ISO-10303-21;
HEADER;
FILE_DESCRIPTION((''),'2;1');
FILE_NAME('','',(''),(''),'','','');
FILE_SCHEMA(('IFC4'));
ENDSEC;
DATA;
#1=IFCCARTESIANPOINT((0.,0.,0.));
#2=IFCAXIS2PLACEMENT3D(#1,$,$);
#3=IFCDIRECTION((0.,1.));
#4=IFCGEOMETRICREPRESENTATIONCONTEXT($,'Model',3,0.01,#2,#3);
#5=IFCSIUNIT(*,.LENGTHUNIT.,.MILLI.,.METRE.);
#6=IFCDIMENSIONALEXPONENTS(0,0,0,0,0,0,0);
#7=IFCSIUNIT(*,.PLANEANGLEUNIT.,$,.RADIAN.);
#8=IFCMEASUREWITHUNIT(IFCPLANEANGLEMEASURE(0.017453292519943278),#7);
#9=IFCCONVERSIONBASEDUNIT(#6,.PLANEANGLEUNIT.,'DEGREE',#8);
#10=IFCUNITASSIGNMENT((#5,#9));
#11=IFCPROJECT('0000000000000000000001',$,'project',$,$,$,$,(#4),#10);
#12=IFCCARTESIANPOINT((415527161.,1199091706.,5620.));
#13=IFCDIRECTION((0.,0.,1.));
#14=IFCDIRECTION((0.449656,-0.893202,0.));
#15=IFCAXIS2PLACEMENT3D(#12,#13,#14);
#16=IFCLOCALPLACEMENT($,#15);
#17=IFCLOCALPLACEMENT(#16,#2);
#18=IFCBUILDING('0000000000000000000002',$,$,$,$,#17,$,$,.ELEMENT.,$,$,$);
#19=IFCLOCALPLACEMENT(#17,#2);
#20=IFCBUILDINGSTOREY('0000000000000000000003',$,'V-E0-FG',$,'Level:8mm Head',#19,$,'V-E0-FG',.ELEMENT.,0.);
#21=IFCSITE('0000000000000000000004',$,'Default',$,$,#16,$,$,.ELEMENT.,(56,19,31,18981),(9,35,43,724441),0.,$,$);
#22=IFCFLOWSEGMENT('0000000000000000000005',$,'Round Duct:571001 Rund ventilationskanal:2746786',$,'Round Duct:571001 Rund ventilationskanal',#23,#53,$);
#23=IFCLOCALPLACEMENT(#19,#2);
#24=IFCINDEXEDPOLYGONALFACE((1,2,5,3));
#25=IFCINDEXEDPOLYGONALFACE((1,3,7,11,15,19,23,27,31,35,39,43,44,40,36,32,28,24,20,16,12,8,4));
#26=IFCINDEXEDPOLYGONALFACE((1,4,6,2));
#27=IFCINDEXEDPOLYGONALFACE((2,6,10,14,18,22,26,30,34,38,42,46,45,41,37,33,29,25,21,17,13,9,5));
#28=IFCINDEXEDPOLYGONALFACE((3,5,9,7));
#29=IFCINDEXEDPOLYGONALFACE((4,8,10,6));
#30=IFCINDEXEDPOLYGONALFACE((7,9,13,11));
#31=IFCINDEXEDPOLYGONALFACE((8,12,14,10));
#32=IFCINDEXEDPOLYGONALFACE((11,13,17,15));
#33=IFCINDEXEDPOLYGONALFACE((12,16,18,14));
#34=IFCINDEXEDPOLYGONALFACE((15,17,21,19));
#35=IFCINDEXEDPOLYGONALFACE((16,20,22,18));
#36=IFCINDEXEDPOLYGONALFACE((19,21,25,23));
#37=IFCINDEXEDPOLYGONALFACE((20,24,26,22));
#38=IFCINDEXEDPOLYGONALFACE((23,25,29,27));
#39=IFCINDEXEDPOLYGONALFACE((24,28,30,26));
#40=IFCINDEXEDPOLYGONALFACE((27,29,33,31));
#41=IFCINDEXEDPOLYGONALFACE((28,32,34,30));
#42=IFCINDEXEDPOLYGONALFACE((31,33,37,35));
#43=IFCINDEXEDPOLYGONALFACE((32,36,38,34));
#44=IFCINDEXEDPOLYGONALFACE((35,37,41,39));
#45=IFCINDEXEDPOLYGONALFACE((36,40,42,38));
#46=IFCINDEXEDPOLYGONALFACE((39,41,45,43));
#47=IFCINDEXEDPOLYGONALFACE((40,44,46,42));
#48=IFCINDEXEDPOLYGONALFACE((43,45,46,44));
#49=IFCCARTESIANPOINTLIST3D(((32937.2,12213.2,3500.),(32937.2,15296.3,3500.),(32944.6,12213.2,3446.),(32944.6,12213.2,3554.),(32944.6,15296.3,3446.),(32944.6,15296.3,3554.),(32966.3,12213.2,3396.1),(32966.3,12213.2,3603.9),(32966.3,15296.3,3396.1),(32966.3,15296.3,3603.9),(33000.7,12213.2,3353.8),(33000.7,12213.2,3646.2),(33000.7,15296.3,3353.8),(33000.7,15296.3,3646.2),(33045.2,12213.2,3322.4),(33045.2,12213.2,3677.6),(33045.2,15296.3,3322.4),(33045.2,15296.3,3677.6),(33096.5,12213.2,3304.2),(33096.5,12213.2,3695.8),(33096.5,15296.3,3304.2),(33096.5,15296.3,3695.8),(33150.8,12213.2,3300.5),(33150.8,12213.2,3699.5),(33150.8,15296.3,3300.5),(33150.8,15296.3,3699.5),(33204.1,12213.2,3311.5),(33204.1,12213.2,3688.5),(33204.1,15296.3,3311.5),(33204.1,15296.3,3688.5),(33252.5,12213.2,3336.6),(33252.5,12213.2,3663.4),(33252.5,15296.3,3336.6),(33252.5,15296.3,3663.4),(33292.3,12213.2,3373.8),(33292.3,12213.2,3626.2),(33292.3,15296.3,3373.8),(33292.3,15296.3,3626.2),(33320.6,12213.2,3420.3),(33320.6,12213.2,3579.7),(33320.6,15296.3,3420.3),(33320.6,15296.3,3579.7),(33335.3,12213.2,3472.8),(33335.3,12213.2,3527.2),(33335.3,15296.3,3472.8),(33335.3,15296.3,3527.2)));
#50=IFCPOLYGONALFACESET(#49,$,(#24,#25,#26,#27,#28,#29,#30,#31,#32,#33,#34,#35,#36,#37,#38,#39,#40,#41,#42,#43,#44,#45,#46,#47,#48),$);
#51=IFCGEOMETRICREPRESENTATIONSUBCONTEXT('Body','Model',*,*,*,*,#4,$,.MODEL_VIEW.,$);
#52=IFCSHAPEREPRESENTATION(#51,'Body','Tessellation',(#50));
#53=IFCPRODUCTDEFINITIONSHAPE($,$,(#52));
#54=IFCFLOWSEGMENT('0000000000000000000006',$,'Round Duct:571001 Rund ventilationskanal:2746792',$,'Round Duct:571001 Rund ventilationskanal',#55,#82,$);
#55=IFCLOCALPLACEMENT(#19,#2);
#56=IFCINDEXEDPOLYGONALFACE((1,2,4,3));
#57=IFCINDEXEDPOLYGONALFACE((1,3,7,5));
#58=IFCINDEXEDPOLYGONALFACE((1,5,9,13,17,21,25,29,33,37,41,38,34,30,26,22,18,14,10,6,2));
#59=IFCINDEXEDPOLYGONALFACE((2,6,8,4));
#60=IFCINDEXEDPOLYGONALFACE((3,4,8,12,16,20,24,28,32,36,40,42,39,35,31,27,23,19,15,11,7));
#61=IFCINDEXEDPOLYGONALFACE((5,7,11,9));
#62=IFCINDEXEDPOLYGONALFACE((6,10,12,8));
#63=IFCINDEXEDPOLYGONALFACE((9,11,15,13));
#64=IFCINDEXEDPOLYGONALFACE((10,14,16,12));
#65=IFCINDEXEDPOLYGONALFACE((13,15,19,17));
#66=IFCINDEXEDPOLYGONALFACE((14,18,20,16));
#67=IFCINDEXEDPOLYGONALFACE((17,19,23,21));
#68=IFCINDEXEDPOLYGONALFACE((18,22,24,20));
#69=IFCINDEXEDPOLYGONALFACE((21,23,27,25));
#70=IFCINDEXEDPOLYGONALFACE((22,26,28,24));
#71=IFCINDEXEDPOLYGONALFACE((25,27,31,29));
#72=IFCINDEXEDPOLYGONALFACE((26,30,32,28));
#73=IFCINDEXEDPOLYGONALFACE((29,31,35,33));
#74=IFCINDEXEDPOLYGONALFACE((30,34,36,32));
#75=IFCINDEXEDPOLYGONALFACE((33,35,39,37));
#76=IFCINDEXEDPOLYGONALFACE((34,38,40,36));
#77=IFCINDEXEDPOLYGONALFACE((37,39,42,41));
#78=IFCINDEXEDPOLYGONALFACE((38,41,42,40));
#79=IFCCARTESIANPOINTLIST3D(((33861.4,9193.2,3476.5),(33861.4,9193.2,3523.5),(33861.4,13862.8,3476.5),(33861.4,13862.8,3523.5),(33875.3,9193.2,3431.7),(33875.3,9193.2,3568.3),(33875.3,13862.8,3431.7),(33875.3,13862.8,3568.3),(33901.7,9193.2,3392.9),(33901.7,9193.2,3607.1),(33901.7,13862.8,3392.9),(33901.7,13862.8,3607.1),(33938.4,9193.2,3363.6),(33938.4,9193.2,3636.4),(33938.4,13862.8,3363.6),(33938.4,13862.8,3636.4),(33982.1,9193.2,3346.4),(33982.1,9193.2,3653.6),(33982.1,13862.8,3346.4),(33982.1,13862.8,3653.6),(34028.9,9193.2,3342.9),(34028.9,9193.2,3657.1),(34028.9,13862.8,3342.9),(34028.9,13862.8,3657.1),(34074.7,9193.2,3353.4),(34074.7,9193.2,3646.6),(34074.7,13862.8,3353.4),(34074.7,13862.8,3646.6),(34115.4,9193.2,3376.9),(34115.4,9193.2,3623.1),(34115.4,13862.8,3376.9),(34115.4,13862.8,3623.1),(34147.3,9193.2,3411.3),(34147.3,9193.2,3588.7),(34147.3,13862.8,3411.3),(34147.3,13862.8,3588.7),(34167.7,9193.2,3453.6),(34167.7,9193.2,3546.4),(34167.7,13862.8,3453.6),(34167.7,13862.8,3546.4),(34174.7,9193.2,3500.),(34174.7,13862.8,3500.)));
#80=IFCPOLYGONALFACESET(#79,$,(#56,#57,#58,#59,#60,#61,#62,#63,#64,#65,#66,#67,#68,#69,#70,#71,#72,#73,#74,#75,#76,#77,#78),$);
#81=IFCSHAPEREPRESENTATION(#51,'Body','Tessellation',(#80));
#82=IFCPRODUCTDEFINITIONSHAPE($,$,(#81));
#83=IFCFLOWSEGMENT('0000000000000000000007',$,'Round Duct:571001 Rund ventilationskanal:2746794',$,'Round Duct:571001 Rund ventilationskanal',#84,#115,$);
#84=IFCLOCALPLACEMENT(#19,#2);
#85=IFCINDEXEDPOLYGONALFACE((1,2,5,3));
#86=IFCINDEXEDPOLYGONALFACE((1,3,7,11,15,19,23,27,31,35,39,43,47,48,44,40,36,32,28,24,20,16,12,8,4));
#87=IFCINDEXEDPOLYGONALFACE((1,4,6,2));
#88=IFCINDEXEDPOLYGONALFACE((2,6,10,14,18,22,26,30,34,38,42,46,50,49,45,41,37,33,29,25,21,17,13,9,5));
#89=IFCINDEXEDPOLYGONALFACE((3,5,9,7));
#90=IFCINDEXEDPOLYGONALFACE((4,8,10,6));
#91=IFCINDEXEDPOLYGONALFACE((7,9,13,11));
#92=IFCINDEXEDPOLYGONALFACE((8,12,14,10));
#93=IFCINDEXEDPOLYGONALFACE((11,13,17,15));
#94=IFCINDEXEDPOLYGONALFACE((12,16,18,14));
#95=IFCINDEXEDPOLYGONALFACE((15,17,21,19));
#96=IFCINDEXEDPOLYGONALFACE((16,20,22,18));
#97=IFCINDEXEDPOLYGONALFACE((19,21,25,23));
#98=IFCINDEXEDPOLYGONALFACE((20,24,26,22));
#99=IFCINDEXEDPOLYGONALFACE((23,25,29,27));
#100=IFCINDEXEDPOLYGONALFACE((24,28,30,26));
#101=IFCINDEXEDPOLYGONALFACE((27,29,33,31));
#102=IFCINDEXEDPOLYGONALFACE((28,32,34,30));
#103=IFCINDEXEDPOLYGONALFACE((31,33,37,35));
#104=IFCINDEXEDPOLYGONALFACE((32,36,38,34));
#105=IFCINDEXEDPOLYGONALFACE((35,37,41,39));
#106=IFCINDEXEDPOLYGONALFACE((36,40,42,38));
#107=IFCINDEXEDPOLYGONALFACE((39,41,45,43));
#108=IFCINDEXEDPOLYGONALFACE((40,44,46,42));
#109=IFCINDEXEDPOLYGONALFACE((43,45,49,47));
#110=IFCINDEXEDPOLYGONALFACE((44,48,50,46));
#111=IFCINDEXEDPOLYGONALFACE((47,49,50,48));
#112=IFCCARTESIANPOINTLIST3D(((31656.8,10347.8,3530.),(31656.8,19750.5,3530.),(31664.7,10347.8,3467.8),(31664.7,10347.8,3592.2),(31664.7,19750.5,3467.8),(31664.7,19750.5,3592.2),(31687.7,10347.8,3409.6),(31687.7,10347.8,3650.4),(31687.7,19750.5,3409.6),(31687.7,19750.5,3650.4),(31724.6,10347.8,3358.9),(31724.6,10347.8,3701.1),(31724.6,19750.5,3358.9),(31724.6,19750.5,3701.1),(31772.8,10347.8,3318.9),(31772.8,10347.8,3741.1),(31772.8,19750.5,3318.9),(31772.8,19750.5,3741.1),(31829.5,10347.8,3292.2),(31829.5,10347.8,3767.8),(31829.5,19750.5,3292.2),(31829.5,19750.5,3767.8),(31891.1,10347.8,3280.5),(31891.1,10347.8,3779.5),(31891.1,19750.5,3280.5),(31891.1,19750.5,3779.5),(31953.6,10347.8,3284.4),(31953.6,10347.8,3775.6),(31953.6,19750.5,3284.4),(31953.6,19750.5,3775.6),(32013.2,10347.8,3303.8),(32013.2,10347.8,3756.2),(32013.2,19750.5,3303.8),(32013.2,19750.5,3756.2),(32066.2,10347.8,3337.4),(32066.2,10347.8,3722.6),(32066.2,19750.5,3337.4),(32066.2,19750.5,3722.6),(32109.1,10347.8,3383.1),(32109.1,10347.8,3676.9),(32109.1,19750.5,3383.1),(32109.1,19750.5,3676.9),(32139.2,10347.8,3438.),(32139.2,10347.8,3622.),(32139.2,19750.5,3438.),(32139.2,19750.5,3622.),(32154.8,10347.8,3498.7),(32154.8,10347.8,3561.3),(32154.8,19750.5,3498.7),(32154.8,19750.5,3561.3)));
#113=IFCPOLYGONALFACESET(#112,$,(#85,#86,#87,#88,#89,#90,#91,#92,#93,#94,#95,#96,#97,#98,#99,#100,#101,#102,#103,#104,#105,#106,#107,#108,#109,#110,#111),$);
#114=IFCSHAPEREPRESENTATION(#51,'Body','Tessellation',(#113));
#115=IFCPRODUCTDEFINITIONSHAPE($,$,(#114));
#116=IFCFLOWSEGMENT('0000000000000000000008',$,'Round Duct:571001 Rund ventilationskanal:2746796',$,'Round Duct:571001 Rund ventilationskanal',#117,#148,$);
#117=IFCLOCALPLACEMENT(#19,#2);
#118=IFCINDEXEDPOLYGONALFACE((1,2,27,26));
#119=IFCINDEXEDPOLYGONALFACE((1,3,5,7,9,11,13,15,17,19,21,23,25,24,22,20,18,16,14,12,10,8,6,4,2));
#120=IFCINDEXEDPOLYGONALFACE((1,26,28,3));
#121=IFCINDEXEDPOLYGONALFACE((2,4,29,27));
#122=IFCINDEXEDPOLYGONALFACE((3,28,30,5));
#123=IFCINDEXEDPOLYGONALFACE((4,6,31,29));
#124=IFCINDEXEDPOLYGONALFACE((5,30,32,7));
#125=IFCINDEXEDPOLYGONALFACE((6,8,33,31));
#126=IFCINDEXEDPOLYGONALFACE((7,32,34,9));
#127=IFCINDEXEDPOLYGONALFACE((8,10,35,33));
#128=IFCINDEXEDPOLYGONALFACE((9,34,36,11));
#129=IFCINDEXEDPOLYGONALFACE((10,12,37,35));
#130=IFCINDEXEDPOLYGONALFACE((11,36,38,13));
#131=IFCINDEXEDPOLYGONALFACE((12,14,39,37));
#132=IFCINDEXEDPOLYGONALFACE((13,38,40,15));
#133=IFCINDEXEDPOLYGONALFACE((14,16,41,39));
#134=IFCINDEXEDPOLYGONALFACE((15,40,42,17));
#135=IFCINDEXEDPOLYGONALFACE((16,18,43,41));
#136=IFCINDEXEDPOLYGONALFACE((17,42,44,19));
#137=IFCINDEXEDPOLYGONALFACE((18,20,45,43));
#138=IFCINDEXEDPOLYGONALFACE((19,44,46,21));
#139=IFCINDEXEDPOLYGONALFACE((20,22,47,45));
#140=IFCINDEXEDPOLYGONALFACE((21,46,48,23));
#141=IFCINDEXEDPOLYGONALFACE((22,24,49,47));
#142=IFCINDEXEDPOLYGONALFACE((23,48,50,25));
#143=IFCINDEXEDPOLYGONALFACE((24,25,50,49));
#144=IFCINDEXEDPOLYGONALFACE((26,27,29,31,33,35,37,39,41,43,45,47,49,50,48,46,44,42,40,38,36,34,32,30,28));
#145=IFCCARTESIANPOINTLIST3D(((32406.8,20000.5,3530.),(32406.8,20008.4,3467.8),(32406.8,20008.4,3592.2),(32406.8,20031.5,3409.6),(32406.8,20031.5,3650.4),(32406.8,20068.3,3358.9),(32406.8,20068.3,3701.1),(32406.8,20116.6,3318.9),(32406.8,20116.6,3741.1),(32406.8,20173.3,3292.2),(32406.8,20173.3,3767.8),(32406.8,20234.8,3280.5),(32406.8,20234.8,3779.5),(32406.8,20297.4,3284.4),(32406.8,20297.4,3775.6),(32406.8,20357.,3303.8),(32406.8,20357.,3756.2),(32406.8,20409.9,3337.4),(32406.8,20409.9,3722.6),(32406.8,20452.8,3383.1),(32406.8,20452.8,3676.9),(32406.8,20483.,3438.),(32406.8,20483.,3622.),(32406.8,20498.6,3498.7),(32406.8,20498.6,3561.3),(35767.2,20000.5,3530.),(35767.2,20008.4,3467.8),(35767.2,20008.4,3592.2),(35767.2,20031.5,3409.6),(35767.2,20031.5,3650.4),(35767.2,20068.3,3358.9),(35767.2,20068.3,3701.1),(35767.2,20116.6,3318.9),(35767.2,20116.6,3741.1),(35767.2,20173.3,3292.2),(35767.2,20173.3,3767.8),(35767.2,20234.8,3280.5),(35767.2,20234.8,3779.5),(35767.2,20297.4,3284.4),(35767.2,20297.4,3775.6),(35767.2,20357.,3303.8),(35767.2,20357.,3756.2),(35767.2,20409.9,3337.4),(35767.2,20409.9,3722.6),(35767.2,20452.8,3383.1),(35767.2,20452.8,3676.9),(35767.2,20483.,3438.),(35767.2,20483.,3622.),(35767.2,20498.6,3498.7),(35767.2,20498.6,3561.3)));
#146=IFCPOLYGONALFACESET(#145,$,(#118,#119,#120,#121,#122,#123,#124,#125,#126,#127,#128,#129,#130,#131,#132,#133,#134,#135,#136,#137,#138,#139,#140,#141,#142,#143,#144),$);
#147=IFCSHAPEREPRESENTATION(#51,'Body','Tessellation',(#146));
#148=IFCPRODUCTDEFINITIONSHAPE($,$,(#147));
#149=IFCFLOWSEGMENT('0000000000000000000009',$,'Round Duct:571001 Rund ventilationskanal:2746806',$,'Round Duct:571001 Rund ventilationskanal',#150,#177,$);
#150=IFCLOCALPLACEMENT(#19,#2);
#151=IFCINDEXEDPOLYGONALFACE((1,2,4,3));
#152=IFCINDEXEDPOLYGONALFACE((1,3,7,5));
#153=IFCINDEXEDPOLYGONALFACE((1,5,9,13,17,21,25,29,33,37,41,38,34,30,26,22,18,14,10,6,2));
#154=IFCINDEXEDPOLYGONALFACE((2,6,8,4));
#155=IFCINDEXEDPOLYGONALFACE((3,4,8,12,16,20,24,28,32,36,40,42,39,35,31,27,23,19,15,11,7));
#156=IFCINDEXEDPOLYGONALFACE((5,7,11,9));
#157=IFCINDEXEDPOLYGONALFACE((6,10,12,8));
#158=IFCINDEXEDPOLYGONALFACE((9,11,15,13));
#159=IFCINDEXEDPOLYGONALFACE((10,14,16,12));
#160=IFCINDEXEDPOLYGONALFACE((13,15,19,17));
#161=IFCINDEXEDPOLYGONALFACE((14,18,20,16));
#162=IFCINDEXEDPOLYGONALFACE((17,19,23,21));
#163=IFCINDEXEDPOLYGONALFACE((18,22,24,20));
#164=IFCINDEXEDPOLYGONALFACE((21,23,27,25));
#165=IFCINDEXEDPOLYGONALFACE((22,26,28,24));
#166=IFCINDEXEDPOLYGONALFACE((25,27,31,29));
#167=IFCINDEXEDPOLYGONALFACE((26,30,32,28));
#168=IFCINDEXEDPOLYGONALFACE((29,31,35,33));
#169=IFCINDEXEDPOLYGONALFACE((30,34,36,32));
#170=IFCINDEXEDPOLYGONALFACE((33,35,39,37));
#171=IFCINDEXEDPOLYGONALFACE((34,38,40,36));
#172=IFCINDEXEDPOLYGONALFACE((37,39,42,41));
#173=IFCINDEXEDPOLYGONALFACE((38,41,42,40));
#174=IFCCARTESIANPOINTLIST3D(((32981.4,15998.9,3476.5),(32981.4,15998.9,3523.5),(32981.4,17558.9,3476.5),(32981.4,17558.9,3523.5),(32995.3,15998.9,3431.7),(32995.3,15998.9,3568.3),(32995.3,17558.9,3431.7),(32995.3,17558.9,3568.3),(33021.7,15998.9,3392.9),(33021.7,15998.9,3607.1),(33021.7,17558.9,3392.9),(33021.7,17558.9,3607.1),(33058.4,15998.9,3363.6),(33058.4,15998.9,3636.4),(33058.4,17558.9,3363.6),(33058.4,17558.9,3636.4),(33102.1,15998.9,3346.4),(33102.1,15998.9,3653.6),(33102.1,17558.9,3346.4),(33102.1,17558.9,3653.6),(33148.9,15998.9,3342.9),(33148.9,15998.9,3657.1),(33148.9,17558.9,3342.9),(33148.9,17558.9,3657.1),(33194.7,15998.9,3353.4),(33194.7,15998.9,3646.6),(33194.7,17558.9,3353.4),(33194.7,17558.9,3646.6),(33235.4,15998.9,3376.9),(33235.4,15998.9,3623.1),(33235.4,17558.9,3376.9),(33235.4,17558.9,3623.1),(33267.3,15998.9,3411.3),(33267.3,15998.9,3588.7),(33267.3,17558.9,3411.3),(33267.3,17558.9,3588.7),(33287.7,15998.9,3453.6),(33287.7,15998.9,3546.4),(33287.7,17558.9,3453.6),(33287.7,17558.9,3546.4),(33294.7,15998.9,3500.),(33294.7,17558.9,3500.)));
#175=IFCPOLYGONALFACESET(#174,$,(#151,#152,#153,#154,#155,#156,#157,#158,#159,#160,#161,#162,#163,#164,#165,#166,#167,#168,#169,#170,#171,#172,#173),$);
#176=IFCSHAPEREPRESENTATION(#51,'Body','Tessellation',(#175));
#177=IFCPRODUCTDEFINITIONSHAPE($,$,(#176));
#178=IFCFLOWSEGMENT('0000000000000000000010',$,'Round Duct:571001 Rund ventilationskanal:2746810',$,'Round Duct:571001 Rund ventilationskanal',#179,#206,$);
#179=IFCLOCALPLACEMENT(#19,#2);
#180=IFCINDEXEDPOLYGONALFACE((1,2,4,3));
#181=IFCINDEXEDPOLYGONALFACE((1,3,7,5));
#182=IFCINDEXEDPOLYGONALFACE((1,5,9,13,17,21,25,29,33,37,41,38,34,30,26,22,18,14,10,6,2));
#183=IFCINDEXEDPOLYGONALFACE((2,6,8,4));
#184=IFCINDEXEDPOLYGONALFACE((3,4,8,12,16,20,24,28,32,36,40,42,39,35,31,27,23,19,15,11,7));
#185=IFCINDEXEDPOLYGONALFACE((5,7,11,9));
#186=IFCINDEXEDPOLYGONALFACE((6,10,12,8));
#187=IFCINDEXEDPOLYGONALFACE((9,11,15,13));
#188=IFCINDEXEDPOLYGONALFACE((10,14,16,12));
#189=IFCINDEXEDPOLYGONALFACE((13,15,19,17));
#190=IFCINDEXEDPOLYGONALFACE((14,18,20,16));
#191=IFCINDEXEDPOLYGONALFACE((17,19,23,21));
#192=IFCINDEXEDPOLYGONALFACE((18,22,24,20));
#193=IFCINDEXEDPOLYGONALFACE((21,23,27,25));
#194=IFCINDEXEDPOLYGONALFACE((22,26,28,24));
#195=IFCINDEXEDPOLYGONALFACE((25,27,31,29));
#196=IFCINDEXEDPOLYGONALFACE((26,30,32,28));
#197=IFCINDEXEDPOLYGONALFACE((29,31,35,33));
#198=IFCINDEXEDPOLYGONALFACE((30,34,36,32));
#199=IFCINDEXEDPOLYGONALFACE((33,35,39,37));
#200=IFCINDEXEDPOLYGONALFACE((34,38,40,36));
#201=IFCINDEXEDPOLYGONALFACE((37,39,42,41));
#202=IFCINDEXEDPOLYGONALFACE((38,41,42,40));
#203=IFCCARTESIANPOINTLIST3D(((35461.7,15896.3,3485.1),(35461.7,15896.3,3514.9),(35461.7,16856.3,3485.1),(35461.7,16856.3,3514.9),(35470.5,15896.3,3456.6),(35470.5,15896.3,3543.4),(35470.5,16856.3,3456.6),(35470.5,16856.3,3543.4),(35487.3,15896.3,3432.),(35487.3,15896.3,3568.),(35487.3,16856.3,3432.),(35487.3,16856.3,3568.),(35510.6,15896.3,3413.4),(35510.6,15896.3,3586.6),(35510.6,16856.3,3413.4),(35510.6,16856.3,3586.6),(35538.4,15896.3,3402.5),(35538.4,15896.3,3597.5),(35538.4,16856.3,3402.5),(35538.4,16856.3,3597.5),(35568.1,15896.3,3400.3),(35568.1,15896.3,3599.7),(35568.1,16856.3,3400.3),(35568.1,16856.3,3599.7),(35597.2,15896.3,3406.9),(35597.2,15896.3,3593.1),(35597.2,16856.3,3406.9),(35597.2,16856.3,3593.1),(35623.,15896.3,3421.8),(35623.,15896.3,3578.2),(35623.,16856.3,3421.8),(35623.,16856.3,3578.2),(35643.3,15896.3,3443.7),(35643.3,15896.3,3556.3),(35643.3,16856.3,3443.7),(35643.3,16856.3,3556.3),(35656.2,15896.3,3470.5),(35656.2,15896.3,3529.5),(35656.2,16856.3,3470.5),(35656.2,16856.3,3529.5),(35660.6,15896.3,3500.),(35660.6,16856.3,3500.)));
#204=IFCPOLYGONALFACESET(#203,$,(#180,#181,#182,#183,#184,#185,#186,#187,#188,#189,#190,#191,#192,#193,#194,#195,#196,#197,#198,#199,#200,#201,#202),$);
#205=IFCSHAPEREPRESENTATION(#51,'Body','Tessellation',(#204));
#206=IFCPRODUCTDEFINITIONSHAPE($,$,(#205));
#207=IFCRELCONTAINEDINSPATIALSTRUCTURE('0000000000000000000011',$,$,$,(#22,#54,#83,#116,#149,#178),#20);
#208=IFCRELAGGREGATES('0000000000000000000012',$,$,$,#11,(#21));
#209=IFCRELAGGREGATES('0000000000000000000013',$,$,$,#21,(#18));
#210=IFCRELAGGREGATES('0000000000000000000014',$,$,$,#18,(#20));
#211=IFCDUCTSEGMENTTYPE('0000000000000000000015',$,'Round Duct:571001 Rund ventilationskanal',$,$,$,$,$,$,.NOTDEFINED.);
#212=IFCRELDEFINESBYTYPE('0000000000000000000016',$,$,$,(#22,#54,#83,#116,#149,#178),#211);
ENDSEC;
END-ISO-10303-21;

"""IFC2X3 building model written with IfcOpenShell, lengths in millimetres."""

from ifc_helpers import new_model, entity, si_unit, converted_unit, direction, frame, frame_2d, origin, origin_2d_with_axis, place, context, subcontext, project, spatial, circle, extrude, type_object, element, save


model = new_model("IFC2X3")

# Units and contexts
model_context = context("Model", 3, precision=0.01, world=origin(), true_north=direction((0.0, 1.0)))
body_context = subcontext(model_context, "Body", "Model", "MODEL_VIEW")
ifc_project = project(units=[si_unit("LENGTHUNIT", "METRE", prefix="MILLI"), converted_unit("PLANEANGLEUNIT", "DEGREE", entity("IfcPlaneAngleMeasure", 0.017453292519943278), si_unit("PLANEANGLEUNIT", "RADIAN"), dimensions=[0, 0, 0, 0, 0, 0, 0])], contexts=[model_context])

# Site, building, storey
site_placement = place(None, frame((415527161.0, 1199091706.0, 5620.0), z_axis=(0.0, 0.0, 1.0), x_axis=(0.449656, -0.893202, 0.0)))
site = spatial("IfcSite", under=ifc_project, at=site_placement, Name="Default", CompositionType="ELEMENT", RefLatitude=(56, 19, 31, 18981), RefLongitude=(9, 35, 43, 724441), RefElevation=0.0)
building_placement = place(site_placement, origin())
building = spatial("IfcBuilding", under=site, at=building_placement, CompositionType="ELEMENT")
storey_placement = place(building_placement, origin())
storey = spatial("IfcBuildingStorey", under=building, at=storey_placement, Name="V-E0-FG", ObjectType="Level:8mm Head", LongName="V-E0-FG", CompositionType="ELEMENT", Elevation=0.0)

# Flow segments
duct_segment_type = type_object("IfcDuctSegmentType", Name="Round Duct:571001 Rund ventilationskanal", PredefinedType="NOTDEFINED")
flow_segment_1_placement = place(storey_placement, origin())
element("IfcFlowSegment", 1, at=flow_segment_1_placement, inside=storey, type_object=duct_segment_type, Name="Round Duct:571001 Rund ventilationskanal:2746786", ObjectType="Round Duct:571001 Rund ventilationskanal", context=body_context, shape_type="SweptSolid", body=[
    extrude(circle(Radius=200.0, at=origin_2d_with_axis()), frame((33137.2, 12213.2, 3500.0), z_axis=(0.0, 1.0, 0.0), x_axis=(-1.0, 0.0, 0.0)), (0.0, 0.0, 1.0), 3083.1),
])
flow_segment_2_placement = place(storey_placement, origin())
element("IfcFlowSegment", 2, at=flow_segment_2_placement, inside=storey, type_object=duct_segment_type, Name="Round Duct:571001 Rund ventilationskanal:2746792", ObjectType="Round Duct:571001 Rund ventilationskanal", context=body_context, shape_type="SweptSolid", body=[
    extrude(circle(Radius=157.5, at=origin_2d_with_axis()), frame((34017.2, 9193.2, 3500.0), z_axis=(0.0, 1.0, 0.0), x_axis=(1.0, 0.0, 0.0)), (0.0, 0.0, 1.0), 4669.5),
])
flow_segment_3_placement = place(storey_placement, origin())
element("IfcFlowSegment", 3, at=flow_segment_3_placement, inside=storey, type_object=duct_segment_type, Name="Round Duct:571001 Rund ventilationskanal:2746794", ObjectType="Round Duct:571001 Rund ventilationskanal", context=body_context, shape_type="SweptSolid", body=[
    extrude(circle(Radius=250.0, at=frame_2d((0.0, 0.0), x_axis=(1.0, 0.0))), frame((31906.8, 10347.8, 3530.0), z_axis=(0.0, 1.0, 0.0), x_axis=(-1.0, 0.0, 0.0)), (0.0, 0.0, 1.0), 9402.7),
])
flow_segment_4_placement = place(storey_placement, origin())
element("IfcFlowSegment", 4, at=flow_segment_4_placement, inside=storey, type_object=duct_segment_type, Name="Round Duct:571001 Rund ventilationskanal:2746796", ObjectType="Round Duct:571001 Rund ventilationskanal", context=body_context, shape_type="SweptSolid", body=[
    extrude(circle(Radius=250.0, at=origin_2d_with_axis()), frame((32406.8, 20250.5, 3530.0), z_axis=(1.0, 0.0, 0.0), x_axis=(0.0, -1.0, 0.0)), (0.0, 0.0, 1.0), 3360.4),
])
flow_segment_5_placement = place(storey_placement, origin())
element("IfcFlowSegment", 5, at=flow_segment_5_placement, inside=storey, type_object=duct_segment_type, Name="Round Duct:571001 Rund ventilationskanal:2746806", ObjectType="Round Duct:571001 Rund ventilationskanal", context=body_context, shape_type="SweptSolid", body=[
    extrude(circle(Radius=157.5, at=origin_2d_with_axis()), frame((33137.2, 15998.9, 3500.0), z_axis=(0.0, 1.0, 0.0), x_axis=(1.0, 0.0, 0.0)), (0.0, 0.0, 1.0), 1560.0),
])
flow_segment_6_placement = place(storey_placement, origin())
element("IfcFlowSegment", 6, at=flow_segment_6_placement, inside=storey, type_object=duct_segment_type, Name="Round Duct:571001 Rund ventilationskanal:2746810", ObjectType="Round Duct:571001 Rund ventilationskanal", context=body_context, shape_type="SweptSolid", body=[
    extrude(circle(Radius=100.0, at=origin_2d_with_axis()), frame((35560.6, 15896.3, 3500.0), z_axis=(0.0, 1.0, 0.0), x_axis=(1.0, 0.0, 0.0)), (0.0, 0.0, 1.0), 960.0),
])

save(model, "model.ifc")
